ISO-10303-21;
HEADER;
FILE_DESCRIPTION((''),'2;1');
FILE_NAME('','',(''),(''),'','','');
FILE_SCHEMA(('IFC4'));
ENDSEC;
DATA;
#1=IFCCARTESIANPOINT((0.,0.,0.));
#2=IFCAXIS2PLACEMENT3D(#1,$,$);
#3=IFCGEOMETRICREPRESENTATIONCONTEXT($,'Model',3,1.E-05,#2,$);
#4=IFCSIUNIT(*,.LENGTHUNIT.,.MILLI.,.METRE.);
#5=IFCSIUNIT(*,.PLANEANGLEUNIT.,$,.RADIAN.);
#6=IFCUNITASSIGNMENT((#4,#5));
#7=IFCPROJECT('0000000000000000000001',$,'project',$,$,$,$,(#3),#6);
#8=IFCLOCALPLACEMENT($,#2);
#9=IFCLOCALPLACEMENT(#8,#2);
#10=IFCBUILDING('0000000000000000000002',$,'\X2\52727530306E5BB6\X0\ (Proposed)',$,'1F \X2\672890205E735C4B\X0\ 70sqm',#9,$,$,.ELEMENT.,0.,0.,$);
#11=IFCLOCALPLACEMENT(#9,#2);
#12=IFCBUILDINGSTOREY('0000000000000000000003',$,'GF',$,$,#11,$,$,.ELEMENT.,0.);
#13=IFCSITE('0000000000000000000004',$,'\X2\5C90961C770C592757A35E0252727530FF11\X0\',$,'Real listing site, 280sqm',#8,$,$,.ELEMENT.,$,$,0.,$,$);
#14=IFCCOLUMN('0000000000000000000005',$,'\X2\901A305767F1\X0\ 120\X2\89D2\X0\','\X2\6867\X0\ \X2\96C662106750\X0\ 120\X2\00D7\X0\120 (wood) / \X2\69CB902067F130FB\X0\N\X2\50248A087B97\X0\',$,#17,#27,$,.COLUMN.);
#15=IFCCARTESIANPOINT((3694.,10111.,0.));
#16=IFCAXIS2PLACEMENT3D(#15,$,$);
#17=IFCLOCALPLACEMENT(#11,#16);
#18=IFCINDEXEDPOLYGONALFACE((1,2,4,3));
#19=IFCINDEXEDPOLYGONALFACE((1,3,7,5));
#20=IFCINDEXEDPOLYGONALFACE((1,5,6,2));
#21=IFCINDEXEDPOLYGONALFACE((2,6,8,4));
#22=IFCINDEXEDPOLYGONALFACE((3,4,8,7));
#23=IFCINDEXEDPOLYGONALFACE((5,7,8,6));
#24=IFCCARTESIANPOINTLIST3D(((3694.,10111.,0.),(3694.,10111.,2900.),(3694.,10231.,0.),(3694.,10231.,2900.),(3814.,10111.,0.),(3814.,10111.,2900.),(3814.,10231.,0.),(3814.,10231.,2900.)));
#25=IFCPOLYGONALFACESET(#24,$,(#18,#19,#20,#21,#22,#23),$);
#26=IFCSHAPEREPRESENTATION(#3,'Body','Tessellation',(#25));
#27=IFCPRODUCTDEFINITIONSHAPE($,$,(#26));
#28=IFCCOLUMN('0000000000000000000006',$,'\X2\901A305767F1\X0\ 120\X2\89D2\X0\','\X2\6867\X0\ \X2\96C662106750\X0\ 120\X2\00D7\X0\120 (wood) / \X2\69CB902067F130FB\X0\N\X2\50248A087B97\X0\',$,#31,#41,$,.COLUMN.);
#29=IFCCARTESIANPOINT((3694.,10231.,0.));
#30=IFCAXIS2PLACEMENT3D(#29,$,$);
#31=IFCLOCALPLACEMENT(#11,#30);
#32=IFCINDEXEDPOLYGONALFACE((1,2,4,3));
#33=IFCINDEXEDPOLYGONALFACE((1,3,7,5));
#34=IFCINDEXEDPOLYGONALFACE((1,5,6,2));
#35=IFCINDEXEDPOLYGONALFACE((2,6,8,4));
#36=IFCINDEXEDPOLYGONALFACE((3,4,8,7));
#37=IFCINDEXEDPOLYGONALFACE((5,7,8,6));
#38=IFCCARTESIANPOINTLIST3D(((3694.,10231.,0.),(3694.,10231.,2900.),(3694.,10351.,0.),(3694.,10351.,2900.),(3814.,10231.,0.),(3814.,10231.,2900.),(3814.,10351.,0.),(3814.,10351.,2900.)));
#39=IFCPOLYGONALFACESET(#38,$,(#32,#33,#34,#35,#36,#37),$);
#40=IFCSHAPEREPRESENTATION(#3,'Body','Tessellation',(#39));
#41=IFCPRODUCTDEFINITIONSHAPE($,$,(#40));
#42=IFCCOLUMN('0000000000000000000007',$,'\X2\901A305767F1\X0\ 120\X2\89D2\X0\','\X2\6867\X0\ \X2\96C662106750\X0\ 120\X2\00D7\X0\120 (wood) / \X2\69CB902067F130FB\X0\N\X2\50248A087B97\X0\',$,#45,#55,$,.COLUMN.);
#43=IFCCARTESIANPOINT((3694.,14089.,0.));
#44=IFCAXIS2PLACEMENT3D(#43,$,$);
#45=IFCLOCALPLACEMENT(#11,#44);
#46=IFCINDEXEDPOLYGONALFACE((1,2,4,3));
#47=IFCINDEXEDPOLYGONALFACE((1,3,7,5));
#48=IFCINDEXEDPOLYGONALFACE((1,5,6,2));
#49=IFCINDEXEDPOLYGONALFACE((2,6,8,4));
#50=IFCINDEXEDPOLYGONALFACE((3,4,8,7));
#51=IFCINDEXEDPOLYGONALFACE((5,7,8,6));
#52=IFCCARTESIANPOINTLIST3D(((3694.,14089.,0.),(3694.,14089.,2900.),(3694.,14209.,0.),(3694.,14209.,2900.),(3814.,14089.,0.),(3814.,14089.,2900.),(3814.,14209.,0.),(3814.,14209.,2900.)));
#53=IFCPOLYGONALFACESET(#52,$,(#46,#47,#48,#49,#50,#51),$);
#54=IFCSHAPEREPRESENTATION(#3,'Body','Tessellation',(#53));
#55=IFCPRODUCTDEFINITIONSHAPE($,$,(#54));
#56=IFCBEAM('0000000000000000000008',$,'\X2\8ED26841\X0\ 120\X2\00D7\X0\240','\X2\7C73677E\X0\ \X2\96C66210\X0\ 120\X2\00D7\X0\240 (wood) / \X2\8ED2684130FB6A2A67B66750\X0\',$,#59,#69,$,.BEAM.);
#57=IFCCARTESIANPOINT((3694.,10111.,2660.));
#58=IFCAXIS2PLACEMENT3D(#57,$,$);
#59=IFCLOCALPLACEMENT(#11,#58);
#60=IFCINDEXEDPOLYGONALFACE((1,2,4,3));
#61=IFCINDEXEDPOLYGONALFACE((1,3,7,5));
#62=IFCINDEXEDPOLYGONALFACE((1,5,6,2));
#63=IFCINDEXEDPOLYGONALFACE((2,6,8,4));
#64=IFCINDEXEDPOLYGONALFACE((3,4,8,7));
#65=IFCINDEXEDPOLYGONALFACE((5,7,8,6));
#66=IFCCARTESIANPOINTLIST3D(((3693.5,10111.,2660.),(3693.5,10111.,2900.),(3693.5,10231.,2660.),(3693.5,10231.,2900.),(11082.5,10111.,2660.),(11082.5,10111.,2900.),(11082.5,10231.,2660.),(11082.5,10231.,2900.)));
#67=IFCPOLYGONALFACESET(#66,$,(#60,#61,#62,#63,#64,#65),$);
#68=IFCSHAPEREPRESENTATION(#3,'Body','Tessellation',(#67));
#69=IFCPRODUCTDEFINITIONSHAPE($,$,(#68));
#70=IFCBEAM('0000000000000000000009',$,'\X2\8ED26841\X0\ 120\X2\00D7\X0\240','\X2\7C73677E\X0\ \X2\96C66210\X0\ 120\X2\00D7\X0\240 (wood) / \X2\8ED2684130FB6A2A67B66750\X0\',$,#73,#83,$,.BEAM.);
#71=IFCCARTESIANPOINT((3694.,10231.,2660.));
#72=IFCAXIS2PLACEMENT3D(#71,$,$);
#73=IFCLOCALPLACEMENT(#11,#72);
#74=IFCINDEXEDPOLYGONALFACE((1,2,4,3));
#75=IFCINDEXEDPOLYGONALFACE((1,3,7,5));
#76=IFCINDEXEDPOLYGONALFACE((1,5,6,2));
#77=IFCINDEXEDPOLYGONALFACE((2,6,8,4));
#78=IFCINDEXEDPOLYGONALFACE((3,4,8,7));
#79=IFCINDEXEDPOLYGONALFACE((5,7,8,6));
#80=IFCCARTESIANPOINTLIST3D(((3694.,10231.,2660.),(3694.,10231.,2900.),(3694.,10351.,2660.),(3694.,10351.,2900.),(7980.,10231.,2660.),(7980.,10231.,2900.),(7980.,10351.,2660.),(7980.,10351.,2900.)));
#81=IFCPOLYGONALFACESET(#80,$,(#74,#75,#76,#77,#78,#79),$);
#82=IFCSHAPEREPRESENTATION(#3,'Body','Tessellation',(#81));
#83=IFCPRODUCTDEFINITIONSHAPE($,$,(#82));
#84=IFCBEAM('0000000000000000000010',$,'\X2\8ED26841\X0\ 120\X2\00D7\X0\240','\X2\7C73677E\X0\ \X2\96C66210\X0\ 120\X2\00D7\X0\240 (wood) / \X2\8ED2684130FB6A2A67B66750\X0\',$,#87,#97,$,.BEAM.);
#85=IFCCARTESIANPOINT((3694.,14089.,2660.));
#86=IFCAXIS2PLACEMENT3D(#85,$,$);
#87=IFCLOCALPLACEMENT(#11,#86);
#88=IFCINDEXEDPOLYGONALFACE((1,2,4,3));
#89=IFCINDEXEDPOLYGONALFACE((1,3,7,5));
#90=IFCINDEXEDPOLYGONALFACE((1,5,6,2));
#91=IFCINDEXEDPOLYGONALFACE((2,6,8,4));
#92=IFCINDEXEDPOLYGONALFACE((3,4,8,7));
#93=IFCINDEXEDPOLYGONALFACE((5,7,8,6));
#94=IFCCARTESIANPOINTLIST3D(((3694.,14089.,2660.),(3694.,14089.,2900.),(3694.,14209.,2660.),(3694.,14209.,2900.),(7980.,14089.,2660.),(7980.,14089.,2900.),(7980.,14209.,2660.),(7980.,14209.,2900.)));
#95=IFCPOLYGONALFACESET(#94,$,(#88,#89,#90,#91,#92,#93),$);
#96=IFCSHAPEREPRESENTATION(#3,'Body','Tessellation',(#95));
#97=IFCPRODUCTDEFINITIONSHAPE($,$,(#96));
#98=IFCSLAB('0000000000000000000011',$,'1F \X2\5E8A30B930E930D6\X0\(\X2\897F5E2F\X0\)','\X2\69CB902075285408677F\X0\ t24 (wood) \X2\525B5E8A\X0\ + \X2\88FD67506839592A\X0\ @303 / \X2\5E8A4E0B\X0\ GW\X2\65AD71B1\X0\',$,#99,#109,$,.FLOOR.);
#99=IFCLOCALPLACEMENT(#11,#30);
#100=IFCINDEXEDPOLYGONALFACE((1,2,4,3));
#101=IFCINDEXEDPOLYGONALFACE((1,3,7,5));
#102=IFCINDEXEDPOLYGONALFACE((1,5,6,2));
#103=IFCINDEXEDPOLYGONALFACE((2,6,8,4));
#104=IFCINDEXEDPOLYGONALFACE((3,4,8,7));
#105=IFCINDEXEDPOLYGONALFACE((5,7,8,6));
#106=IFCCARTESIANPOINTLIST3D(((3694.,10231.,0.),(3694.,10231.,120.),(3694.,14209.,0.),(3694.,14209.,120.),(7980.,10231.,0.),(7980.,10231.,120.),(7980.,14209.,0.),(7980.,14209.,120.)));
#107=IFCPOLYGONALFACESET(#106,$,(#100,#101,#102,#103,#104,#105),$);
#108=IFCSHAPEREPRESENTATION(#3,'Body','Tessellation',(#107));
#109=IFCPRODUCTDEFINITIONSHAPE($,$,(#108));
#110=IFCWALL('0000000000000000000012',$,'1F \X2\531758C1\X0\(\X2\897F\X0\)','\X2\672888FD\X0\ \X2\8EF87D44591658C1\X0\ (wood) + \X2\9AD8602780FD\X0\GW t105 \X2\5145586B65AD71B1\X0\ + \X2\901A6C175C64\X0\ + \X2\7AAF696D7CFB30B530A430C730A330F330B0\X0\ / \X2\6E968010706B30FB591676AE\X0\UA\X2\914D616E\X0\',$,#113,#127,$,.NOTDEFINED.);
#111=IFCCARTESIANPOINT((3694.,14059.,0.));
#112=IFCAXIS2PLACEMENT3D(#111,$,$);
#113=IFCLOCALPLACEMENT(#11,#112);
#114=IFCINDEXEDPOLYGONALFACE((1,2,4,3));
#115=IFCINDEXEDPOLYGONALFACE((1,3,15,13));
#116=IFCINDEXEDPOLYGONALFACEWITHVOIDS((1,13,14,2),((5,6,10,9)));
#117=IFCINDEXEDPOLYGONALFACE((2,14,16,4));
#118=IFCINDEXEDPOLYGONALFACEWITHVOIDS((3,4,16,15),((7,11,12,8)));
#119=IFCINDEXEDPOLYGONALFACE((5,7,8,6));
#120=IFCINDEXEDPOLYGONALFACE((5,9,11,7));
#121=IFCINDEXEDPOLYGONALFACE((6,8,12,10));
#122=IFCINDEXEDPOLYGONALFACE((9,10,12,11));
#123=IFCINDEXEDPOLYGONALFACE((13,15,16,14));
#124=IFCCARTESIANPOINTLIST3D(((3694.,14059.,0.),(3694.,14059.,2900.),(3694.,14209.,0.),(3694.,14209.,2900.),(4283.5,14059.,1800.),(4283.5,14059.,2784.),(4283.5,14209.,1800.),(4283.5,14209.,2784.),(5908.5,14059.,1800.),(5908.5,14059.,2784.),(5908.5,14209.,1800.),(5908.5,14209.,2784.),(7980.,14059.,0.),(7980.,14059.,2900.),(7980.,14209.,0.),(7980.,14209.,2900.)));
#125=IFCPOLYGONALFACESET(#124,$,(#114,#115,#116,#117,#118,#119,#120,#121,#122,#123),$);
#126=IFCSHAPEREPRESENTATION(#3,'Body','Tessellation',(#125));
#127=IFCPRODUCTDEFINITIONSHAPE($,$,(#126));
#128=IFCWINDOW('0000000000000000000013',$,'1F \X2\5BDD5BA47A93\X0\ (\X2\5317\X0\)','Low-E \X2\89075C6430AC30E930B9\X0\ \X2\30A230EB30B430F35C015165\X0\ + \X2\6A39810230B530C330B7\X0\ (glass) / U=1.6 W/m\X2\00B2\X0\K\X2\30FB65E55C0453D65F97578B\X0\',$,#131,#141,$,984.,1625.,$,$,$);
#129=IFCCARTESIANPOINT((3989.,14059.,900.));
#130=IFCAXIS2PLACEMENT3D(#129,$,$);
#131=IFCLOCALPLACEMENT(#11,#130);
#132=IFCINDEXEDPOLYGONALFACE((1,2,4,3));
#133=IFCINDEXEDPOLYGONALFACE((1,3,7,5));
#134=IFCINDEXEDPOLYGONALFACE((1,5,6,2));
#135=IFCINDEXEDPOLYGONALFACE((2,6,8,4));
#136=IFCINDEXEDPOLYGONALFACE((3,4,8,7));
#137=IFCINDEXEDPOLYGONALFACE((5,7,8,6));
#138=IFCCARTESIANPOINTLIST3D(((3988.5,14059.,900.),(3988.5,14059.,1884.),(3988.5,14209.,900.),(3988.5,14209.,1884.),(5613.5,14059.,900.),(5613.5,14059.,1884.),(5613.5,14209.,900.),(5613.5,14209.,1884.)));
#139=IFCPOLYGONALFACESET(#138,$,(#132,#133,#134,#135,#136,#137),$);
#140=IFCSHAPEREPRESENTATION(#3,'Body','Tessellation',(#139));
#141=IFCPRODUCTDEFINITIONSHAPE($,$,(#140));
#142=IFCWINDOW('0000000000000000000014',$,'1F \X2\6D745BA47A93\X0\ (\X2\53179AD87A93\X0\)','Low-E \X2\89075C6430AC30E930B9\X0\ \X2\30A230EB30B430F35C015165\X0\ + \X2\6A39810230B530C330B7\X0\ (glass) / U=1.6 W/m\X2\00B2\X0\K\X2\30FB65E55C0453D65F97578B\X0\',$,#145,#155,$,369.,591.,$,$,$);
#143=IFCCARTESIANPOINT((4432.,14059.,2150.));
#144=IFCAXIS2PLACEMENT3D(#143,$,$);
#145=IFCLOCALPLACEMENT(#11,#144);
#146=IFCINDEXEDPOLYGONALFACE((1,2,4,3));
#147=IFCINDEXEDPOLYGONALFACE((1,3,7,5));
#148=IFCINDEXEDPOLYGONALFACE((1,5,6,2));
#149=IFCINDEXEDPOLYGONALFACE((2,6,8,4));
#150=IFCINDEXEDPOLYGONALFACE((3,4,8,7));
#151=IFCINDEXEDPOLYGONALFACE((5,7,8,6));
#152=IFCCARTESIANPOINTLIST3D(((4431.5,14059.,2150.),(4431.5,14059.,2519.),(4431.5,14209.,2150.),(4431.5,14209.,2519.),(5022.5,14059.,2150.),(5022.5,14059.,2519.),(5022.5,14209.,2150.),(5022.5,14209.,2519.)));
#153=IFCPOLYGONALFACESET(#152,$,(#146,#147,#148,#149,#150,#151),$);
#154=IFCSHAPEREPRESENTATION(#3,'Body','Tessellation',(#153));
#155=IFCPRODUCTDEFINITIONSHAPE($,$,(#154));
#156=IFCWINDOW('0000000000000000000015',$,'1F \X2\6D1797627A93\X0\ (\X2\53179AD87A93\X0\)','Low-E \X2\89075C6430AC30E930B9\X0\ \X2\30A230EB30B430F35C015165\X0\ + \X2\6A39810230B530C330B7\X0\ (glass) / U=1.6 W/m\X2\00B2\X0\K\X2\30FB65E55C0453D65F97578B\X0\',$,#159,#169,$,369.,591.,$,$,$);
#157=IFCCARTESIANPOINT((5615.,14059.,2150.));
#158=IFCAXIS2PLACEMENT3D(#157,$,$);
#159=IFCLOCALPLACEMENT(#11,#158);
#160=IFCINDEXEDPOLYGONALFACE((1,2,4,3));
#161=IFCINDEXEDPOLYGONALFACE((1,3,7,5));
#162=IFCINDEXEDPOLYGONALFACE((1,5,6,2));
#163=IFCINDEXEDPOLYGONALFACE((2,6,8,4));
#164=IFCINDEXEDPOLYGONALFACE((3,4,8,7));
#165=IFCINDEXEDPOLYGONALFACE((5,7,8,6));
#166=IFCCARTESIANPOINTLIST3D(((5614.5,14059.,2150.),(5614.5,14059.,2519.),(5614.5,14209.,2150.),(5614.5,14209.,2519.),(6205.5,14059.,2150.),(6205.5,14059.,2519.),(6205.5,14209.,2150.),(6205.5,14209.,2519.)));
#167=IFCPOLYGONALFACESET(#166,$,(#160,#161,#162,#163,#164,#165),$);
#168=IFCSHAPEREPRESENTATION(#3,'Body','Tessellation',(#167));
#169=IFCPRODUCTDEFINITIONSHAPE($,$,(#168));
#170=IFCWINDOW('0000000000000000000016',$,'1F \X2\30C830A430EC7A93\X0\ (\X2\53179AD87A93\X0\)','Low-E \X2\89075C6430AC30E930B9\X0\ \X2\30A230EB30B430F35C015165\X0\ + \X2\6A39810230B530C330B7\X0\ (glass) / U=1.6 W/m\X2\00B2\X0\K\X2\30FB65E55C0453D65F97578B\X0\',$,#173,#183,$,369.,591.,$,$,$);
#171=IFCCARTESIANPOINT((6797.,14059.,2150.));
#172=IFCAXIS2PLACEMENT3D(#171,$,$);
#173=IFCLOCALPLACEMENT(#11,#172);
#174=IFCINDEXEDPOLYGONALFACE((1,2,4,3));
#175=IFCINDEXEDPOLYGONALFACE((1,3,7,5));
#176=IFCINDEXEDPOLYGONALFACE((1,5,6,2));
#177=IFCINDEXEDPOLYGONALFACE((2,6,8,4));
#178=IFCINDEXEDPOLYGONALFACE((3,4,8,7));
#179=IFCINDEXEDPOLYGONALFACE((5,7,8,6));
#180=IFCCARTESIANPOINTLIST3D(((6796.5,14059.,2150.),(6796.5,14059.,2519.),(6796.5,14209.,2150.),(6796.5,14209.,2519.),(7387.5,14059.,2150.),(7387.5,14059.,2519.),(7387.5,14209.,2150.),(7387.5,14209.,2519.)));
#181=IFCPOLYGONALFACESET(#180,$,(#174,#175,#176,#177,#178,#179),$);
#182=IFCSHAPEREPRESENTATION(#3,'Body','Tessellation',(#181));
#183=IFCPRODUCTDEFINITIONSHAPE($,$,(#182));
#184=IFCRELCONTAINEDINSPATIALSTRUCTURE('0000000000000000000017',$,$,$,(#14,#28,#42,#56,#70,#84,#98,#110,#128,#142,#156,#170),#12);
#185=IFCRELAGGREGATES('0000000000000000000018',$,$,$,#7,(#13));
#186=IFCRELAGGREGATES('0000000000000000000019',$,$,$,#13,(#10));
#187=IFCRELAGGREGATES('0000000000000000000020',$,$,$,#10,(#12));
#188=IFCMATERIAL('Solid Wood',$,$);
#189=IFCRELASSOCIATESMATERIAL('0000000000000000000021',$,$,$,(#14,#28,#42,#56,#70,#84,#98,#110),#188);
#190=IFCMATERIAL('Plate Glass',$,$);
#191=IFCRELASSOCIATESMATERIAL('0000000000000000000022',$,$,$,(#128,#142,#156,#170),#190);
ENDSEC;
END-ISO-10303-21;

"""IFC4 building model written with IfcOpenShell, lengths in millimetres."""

from ifc_helpers import new_model, si_unit, frame, frame_2d, origin, place, context, project, spatial, rectangle, extrude, material, element, fill, save


model = new_model("IFC4")

# Units and contexts
model_context = context("Model", 3, precision=1e-05, world=origin())
ifc_project = project(units=[si_unit("LENGTHUNIT", "METRE", prefix="MILLI"), si_unit("PLANEANGLEUNIT", "RADIAN")], contexts=[model_context])

# Site, building, storey
site_placement = place(None, origin())
site = spatial("IfcSite", under=ifc_project, at=site_placement, Name="岐阜県大垣市割田１", ObjectType="Real listing site, 280sqm", CompositionType="ELEMENT", RefElevation=0.0)
building_placement = place(site_placement, origin())
building = spatial("IfcBuilding", under=site, at=building_placement, Name="割田の家 (Proposed)", ObjectType="1F 木造平屋 70sqm", CompositionType="ELEMENT", ElevationOfRefHeight=0.0, ElevationOfTerrain=0.0)
storey_placement = place(building_placement, origin())
storey = spatial("IfcBuildingStorey", under=building, at=storey_placement, Name="GF", CompositionType="ELEMENT", Elevation=0.0)

# Columns
ifc_material_1 = material(Name="Solid Wood")
column_1_placement = place(storey_placement, frame((3694.0, 10111.0, 0.0)))
element("IfcColumn", 1, at=column_1_placement, inside=storey, material=ifc_material_1, Name="通し柱 120角", Description="桧 集成材 120×120 (wood) / 構造柱・N値計算", PredefinedType="COLUMN", context=model_context, shape_type="SweptSolid", body=[
    extrude(rectangle(XDim=120.0, YDim=120.0, at=frame_2d((60.0, 60.0))), frame((3694.0, 10111.0, 0.0)), (0.0, 0.0, 1.0), 2900.0),
])
column_2_placement = place(storey_placement, frame((3694.0, 10231.0, 0.0)))
element("IfcColumn", 2, at=column_2_placement, inside=storey, material=ifc_material_1, Name="通し柱 120角", Description="桧 集成材 120×120 (wood) / 構造柱・N値計算", PredefinedType="COLUMN", context=model_context, shape_type="SweptSolid", body=[
    extrude(rectangle(XDim=120.0, YDim=120.0, at=frame_2d((60.0, 60.0))), frame((3694.0, 10231.0, 0.0)), (0.0, 0.0, 1.0), 2900.0),
])
column_3_placement = place(storey_placement, frame((3694.0, 14089.0, 0.0)))
element("IfcColumn", 3, at=column_3_placement, inside=storey, material=ifc_material_1, Name="通し柱 120角", Description="桧 集成材 120×120 (wood) / 構造柱・N値計算", PredefinedType="COLUMN", context=model_context, shape_type="SweptSolid", body=[
    extrude(rectangle(XDim=120.0, YDim=120.0, at=frame_2d((60.0, 60.0))), frame((3694.0, 14089.0, 0.0)), (0.0, 0.0, 1.0), 2900.0),
])

# Beams
beam_1_placement = place(storey_placement, frame((3694.0, 10111.0, 2660.0)))
element("IfcBeam", 4, at=beam_1_placement, inside=storey, material=ifc_material_1, Name="軒桁 120×240", Description="米松 集成 120×240 (wood) / 軒桁・横架材", PredefinedType="BEAM", context=model_context, shape_type="SweptSolid", body=[
    extrude(rectangle(XDim=7389.0, YDim=120.0, at=frame_2d((3694.0, 60.0))), frame((3694.0, 10111.0, 2660.0)), (0.0, 0.0, 1.0), 240.0),
])
beam_2_placement = place(storey_placement, frame((3694.0, 10231.0, 2660.0)))
element("IfcBeam", 5, at=beam_2_placement, inside=storey, material=ifc_material_1, Name="軒桁 120×240", Description="米松 集成 120×240 (wood) / 軒桁・横架材", PredefinedType="BEAM", context=model_context, shape_type="SweptSolid", body=[
    extrude(rectangle(XDim=4286.0, YDim=120.0, at=frame_2d((2143.0, 60.0))), frame((3694.0, 10231.0, 2660.0)), (0.0, 0.0, 1.0), 240.0),
])
beam_3_placement = place(storey_placement, frame((3694.0, 14089.0, 2660.0)))
element("IfcBeam", 6, at=beam_3_placement, inside=storey, material=ifc_material_1, Name="軒桁 120×240", Description="米松 集成 120×240 (wood) / 軒桁・横架材", PredefinedType="BEAM", context=model_context, shape_type="SweptSolid", body=[
    extrude(rectangle(XDim=4286.0, YDim=120.0, at=frame_2d((2143.0, 60.0))), frame((3694.0, 14089.0, 2660.0)), (0.0, 0.0, 1.0), 240.0),
])

# Slab
slab_placement = place(storey_placement, frame((3694.0, 10231.0, 0.0)))
element("IfcSlab", 7, at=slab_placement, inside=storey, material=ifc_material_1, Name="1F 床スラブ(西帯)", Description="構造用合板 t24 (wood) 剛床 + 製材根太 @303 / 床下 GW断熱", PredefinedType="FLOOR", context=model_context, shape_type="SweptSolid", body=[
    extrude(rectangle(XDim=4286.0, YDim=3978.0, at=frame_2d((2143.0, 1989.0))), frame((3694.0, 10231.0, 0.0)), (0.0, 0.0, 1.0), 120.0),
])

# Wall, openings, windows
wall_1_placement = place(storey_placement, frame((3694.0, 14059.0, 0.0)))
wall_1 = element("IfcWall", 8, at=wall_1_placement, inside=storey, material=ifc_material_1, Name="1F 北壁(西)", Description="木製 軸組外壁 (wood) + 高性能GW t105 充填断熱 + 通気層 + 窯業系サイディング / 準耐火・外皮UA配慮", PredefinedType="NOTDEFINED", context=model_context, shape_type="SweptSolid", body=[
    extrude(rectangle(XDim=4286.0, YDim=150.0, at=frame_2d((2143.0, 75.0))), frame((3694.0, 14059.0, 0.0)), (0.0, 0.0, 1.0), 2900.0),
])
opening_1_placement = place(storey_placement, frame((3989.0, 14059.0, 900.0)))
opening_1 = element("IfcOpeningElement", 9, at=opening_1_placement, cuts=wall_1, PredefinedType="NOTDEFINED", context=model_context, shape_type="SweptSolid", body=[
    extrude(rectangle(XDim=1625.0, YDim=150.0, at=frame_2d((812.0, 75.0))), frame((3989.0, 14059.0, 900.0)), (0.0, 0.0, 1.0), 984.0),
])
opening_2_placement = place(storey_placement, frame((4432.0, 14059.0, 2150.0)))
opening_2 = element("IfcOpeningElement", 10, at=opening_2_placement, cuts=wall_1, PredefinedType="NOTDEFINED", context=model_context, shape_type="SweptSolid", body=[
    extrude(rectangle(XDim=591.0, YDim=150.0, at=frame_2d((295.0, 75.0))), frame((4432.0, 14059.0, 2150.0)), (0.0, 0.0, 1.0), 369.0),
])
opening_3_placement = place(storey_placement, frame((5615.0, 14059.0, 2150.0)))
opening_3 = element("IfcOpeningElement", 11, at=opening_3_placement, cuts=wall_1, PredefinedType="NOTDEFINED", context=model_context, shape_type="SweptSolid", body=[
    extrude(rectangle(XDim=591.0, YDim=150.0, at=frame_2d((295.0, 75.0))), frame((5615.0, 14059.0, 2150.0)), (0.0, 0.0, 1.0), 369.0),
])
opening_4_placement = place(storey_placement, frame((6797.0, 14059.0, 2150.0)))
opening_4 = element("IfcOpeningElement", 12, at=opening_4_placement, cuts=wall_1, PredefinedType="NOTDEFINED", context=model_context, shape_type="SweptSolid", body=[
    extrude(rectangle(XDim=591.0, YDim=150.0, at=frame_2d((295.0, 75.0))), frame((6797.0, 14059.0, 2150.0)), (0.0, 0.0, 1.0), 369.0),
])
ifc_material_2 = material(Name="Plate Glass")
window_1_placement = place(storey_placement, frame((3989.0, 14059.0, 900.0)))
window_1 = element("IfcWindow", 13, at=window_1_placement, inside=storey, material=ifc_material_2, Name="1F 寝室窓 (北)", Description="Low-E 複層ガラス アルゴン封入 + 樹脂サッシ (glass) / U=1.6 W/m²K・日射取得型", OverallHeight=984.0, OverallWidth=1625.0, context=model_context, shape_type="SweptSolid", body=[
    extrude(rectangle(XDim=1625.0, YDim=150.0, at=frame_2d((812.0, 75.0))), frame((3989.0, 14059.0, 900.0)), (0.0, 0.0, 1.0), 984.0),
])
fill(opening_1, window_1)
window_2_placement = place(storey_placement, frame((4432.0, 14059.0, 2150.0)))
window_2 = element("IfcWindow", 14, at=window_2_placement, inside=storey, material=ifc_material_2, Name="1F 浴室窓 (北高窓)", Description="Low-E 複層ガラス アルゴン封入 + 樹脂サッシ (glass) / U=1.6 W/m²K・日射取得型", OverallHeight=369.0, OverallWidth=591.0, context=model_context, shape_type="SweptSolid", body=[
    extrude(rectangle(XDim=591.0, YDim=150.0, at=frame_2d((295.0, 75.0))), frame((4432.0, 14059.0, 2150.0)), (0.0, 0.0, 1.0), 369.0),
])
fill(opening_2, window_2)
window_3_placement = place(storey_placement, frame((5615.0, 14059.0, 2150.0)))
window_3 = element("IfcWindow", 15, at=window_3_placement, inside=storey, material=ifc_material_2, Name="1F 洗面窓 (北高窓)", Description="Low-E 複層ガラス アルゴン封入 + 樹脂サッシ (glass) / U=1.6 W/m²K・日射取得型", OverallHeight=369.0, OverallWidth=591.0, context=model_context, shape_type="SweptSolid", body=[
    extrude(rectangle(XDim=591.0, YDim=150.0, at=frame_2d((295.0, 75.0))), frame((5615.0, 14059.0, 2150.0)), (0.0, 0.0, 1.0), 369.0),
])
fill(opening_3, window_3)
window_4_placement = place(storey_placement, frame((6797.0, 14059.0, 2150.0)))
window_4 = element("IfcWindow", 16, at=window_4_placement, inside=storey, material=ifc_material_2, Name="1F トイレ窓 (北高窓)", Description="Low-E 複層ガラス アルゴン封入 + 樹脂サッシ (glass) / U=1.6 W/m²K・日射取得型", OverallHeight=369.0, OverallWidth=591.0, context=model_context, shape_type="SweptSolid", body=[
    extrude(rectangle(XDim=591.0, YDim=150.0, at=frame_2d((295.0, 75.0))), frame((6797.0, 14059.0, 2150.0)), (0.0, 0.0, 1.0), 369.0),
])
fill(opening_4, window_4)

save(model, "model.ifc")
